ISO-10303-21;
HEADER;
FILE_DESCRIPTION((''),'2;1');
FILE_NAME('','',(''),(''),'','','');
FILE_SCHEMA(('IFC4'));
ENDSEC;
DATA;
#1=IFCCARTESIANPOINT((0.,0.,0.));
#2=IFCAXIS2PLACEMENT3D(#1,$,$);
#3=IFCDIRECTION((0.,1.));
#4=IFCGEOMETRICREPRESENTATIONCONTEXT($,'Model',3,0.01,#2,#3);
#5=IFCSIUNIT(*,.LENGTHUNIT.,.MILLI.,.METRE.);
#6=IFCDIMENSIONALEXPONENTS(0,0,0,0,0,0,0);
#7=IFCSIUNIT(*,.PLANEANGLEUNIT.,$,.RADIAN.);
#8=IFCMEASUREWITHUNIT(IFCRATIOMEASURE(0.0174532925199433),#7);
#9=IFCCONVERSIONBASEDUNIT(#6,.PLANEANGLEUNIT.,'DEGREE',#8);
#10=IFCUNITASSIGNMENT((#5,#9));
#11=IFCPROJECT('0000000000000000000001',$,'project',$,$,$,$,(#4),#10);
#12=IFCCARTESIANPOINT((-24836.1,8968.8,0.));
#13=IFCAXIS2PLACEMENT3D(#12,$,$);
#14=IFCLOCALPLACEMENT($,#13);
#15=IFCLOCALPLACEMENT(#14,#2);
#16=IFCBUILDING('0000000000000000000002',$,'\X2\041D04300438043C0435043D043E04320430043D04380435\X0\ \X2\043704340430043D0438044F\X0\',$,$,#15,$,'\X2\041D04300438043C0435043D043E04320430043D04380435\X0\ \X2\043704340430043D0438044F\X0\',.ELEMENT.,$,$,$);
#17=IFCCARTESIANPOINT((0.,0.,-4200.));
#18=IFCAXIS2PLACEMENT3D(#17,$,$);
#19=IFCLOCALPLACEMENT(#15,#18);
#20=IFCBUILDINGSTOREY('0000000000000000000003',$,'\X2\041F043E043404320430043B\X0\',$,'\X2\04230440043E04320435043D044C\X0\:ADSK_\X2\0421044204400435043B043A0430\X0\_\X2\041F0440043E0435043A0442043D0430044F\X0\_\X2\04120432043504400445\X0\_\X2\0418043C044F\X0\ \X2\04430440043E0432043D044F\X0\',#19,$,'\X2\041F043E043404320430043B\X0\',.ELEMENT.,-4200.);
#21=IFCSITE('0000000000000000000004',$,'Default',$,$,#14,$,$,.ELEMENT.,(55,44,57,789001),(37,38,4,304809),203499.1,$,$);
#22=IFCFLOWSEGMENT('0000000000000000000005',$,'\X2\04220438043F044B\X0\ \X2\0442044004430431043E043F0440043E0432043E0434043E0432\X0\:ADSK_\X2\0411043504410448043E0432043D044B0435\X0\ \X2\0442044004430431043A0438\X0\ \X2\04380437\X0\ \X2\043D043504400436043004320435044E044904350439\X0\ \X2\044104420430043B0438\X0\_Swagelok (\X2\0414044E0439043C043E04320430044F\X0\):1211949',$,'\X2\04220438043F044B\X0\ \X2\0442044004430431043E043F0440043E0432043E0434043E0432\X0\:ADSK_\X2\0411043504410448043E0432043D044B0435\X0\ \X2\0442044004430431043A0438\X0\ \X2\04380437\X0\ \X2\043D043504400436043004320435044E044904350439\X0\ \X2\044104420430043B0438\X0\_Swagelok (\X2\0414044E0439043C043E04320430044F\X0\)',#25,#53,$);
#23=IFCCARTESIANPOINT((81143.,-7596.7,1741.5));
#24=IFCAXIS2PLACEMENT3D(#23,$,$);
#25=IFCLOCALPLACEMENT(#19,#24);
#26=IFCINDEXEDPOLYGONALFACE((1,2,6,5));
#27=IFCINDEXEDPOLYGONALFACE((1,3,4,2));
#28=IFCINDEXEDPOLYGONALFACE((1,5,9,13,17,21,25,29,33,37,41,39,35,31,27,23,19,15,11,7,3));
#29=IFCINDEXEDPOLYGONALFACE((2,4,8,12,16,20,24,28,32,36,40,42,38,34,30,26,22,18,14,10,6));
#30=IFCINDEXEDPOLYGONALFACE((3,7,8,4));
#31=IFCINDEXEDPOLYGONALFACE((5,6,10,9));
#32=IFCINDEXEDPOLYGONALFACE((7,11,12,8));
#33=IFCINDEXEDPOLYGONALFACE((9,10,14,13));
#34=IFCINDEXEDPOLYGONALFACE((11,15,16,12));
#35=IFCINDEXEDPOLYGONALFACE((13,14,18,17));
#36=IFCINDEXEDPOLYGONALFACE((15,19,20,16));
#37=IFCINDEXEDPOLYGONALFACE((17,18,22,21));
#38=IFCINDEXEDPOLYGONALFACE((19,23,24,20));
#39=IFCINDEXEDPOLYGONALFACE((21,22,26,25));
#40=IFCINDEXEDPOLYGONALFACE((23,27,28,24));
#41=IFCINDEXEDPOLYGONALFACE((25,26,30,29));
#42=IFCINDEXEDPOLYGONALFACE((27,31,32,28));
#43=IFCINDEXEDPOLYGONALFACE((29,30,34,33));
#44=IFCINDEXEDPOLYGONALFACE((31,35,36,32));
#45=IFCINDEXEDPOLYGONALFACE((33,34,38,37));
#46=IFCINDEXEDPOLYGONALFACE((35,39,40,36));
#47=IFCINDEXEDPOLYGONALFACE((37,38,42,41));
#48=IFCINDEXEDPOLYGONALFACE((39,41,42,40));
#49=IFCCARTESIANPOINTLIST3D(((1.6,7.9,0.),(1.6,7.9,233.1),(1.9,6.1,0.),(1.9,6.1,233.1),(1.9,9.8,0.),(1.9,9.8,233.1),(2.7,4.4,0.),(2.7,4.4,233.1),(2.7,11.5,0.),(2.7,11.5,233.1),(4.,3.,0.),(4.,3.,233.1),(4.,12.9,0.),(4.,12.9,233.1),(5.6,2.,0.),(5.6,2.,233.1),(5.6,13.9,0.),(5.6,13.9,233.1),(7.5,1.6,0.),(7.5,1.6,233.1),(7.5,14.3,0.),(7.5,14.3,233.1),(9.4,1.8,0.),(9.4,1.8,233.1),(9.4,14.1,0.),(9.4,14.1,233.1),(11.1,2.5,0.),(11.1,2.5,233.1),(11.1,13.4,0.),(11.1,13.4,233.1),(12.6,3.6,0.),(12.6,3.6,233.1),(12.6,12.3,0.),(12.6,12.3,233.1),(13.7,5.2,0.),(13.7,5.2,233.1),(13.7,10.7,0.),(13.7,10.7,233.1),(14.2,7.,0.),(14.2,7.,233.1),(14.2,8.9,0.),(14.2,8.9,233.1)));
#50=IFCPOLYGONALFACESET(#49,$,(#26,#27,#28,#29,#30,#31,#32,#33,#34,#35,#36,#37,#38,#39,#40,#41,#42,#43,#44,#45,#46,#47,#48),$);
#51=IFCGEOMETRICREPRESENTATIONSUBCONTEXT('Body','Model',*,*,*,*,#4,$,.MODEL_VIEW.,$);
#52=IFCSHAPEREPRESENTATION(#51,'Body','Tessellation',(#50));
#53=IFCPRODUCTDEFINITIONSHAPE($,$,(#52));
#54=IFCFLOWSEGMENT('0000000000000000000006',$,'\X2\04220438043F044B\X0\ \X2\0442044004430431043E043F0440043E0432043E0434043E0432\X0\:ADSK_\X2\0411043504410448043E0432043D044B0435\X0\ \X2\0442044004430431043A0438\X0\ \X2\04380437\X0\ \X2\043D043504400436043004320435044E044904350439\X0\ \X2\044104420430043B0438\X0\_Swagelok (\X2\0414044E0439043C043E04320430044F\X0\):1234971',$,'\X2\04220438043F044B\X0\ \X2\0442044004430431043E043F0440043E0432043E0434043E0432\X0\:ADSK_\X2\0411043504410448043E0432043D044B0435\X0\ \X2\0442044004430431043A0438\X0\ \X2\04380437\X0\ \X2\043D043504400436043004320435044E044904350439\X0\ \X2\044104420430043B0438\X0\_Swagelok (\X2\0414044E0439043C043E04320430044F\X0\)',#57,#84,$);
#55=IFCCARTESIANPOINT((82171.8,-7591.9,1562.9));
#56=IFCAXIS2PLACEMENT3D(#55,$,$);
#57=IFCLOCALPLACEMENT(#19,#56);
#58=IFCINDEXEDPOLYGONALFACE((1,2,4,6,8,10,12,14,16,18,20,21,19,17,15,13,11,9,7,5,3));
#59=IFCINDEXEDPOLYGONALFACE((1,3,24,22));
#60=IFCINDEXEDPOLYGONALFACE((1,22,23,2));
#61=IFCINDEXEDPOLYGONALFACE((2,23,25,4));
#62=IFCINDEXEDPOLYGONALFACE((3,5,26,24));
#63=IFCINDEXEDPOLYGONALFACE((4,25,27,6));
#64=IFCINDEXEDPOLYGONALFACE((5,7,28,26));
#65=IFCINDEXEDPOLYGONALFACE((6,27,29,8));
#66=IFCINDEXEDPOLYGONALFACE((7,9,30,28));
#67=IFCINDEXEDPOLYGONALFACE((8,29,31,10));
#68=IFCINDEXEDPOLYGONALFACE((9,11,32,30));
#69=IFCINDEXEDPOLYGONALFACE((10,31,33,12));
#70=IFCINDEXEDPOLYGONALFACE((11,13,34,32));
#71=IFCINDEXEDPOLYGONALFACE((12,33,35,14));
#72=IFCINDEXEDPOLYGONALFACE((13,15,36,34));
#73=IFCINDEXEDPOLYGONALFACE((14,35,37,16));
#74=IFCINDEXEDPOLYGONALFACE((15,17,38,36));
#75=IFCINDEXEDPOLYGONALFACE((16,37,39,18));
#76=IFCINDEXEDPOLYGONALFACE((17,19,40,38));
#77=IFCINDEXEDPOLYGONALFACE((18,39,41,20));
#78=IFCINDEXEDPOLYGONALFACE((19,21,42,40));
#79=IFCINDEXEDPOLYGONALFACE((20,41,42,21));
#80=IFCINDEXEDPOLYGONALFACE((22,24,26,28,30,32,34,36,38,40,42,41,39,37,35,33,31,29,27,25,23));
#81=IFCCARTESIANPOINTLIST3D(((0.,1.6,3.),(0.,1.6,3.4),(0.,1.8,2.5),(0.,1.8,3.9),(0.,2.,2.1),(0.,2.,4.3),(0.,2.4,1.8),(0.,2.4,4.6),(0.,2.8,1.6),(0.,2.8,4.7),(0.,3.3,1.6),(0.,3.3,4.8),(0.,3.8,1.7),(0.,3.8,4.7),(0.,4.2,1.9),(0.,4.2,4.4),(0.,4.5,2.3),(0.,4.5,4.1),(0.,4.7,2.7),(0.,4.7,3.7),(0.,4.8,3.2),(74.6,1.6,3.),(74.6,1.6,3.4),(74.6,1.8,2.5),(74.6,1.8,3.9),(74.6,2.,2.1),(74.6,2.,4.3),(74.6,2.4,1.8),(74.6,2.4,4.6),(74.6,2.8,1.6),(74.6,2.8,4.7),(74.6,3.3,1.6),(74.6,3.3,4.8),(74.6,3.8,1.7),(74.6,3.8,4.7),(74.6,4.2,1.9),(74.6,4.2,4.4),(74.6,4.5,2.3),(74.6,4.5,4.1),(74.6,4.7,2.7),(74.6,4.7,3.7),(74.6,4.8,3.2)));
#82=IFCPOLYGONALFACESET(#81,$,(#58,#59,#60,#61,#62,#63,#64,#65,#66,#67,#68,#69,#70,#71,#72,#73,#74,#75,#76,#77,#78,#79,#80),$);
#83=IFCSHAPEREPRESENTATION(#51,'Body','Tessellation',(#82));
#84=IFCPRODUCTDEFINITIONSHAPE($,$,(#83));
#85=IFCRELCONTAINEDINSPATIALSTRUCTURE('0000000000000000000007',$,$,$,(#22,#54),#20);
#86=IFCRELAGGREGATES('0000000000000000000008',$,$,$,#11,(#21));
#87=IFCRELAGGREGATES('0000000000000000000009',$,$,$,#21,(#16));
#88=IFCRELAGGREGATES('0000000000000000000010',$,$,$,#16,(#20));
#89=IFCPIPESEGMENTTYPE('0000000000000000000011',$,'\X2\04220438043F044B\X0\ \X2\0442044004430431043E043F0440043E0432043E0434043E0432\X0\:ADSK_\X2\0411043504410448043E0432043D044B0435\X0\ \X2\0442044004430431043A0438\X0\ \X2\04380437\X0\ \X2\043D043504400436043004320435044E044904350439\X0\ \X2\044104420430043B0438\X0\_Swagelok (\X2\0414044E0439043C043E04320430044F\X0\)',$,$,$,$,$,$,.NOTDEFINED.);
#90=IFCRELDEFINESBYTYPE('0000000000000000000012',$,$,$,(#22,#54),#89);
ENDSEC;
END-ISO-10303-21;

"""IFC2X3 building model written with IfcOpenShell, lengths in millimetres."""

from ifc_helpers import new_model, entity, si_unit, converted_unit, direction, frame, origin, origin_2d_with_axis, place, context, subcontext, project, spatial, circle, extrude, type_object, element, save


model = new_model("IFC2X3")

# Units and contexts
model_context = context("Model", 3, precision=0.01, world=origin(), true_north=direction((0.0, 1.0)))
body_context = subcontext(model_context, "Body", "Model", "MODEL_VIEW")
ifc_project = project(units=[si_unit("LENGTHUNIT", "METRE", prefix="MILLI"), converted_unit("PLANEANGLEUNIT", "DEGREE", entity("IfcRatioMeasure", 0.0174532925199433), si_unit("PLANEANGLEUNIT", "RADIAN"), dimensions=[0, 0, 0, 0, 0, 0, 0])], contexts=[model_context])

# Site, building, storey
site_placement = place(None, frame((-24836.1, 8968.8, 0.0)))
site = spatial("IfcSite", under=ifc_project, at=site_placement, Name="Default", CompositionType="ELEMENT", RefLatitude=(55, 44, 57, 789001), RefLongitude=(37, 38, 4, 304809), RefElevation=203499.1)
building_placement = place(site_placement, origin())
building = spatial("IfcBuilding", under=site, at=building_placement, Name="Наименование здания", LongName="Наименование здания", CompositionType="ELEMENT")
storey_placement = place(building_placement, frame((0.0, 0.0, -4200.0)))
storey = spatial("IfcBuildingStorey", under=building, at=storey_placement, Name="Подвал", ObjectType="Уровень:ADSK_Стрелка_Проектная_Вверх_Имя уровня", LongName="Подвал", CompositionType="ELEMENT", Elevation=-4200.0)

# Flow segments
pipe_segment_type = type_object("IfcPipeSegmentType", Name="Типы трубопроводов:ADSK_Бесшовные трубки из нержавеющей стали_Swagelok (Дюймовая)", PredefinedType="NOTDEFINED")
flow_segment_1_placement = place(storey_placement, frame((81143.0, -7596.7, 1741.5)))
element("IfcFlowSegment", 1, at=flow_segment_1_placement, inside=storey, type_object=pipe_segment_type, Name="Типы трубопроводов:ADSK_Бесшовные трубки из нержавеющей стали_Swagelok (Дюймовая):1211949", ObjectType="Типы трубопроводов:ADSK_Бесшовные трубки из нержавеющей стали_Swagelok (Дюймовая)", context=body_context, shape_type="SweptSolid", body=[
    extrude(circle(Radius=6.3, at=origin_2d_with_axis()), frame((8.0, 8.0, 0.0), z_axis=(0.0, 0.0, 1.0), x_axis=(-1.0, 0.0, 0.0)), (0.0, 0.0, 1.0), 233.1),
])
flow_segment_2_placement = place(storey_placement, frame((82171.8, -7591.9, 1562.9)))
element("IfcFlowSegment", 2, at=flow_segment_2_placement, inside=storey, type_object=pipe_segment_type, Name="Типы трубопроводов:ADSK_Бесшовные трубки из нержавеющей стали_Swagelok (Дюймовая):1234971", ObjectType="Типы трубопроводов:ADSK_Бесшовные трубки из нержавеющей стали_Swagelok (Дюймовая)", context=body_context, shape_type="SweptSolid", body=[
    extrude(circle(Radius=1.6, at=origin_2d_with_axis()), frame((0.0, 3.2, 3.2), z_axis=(1.0, 0.0, 0.0), x_axis=(0.0, 1.0, 0.0)), (0.0, 0.0, 1.0), 74.6),
])

save(model, "model.ifc")
